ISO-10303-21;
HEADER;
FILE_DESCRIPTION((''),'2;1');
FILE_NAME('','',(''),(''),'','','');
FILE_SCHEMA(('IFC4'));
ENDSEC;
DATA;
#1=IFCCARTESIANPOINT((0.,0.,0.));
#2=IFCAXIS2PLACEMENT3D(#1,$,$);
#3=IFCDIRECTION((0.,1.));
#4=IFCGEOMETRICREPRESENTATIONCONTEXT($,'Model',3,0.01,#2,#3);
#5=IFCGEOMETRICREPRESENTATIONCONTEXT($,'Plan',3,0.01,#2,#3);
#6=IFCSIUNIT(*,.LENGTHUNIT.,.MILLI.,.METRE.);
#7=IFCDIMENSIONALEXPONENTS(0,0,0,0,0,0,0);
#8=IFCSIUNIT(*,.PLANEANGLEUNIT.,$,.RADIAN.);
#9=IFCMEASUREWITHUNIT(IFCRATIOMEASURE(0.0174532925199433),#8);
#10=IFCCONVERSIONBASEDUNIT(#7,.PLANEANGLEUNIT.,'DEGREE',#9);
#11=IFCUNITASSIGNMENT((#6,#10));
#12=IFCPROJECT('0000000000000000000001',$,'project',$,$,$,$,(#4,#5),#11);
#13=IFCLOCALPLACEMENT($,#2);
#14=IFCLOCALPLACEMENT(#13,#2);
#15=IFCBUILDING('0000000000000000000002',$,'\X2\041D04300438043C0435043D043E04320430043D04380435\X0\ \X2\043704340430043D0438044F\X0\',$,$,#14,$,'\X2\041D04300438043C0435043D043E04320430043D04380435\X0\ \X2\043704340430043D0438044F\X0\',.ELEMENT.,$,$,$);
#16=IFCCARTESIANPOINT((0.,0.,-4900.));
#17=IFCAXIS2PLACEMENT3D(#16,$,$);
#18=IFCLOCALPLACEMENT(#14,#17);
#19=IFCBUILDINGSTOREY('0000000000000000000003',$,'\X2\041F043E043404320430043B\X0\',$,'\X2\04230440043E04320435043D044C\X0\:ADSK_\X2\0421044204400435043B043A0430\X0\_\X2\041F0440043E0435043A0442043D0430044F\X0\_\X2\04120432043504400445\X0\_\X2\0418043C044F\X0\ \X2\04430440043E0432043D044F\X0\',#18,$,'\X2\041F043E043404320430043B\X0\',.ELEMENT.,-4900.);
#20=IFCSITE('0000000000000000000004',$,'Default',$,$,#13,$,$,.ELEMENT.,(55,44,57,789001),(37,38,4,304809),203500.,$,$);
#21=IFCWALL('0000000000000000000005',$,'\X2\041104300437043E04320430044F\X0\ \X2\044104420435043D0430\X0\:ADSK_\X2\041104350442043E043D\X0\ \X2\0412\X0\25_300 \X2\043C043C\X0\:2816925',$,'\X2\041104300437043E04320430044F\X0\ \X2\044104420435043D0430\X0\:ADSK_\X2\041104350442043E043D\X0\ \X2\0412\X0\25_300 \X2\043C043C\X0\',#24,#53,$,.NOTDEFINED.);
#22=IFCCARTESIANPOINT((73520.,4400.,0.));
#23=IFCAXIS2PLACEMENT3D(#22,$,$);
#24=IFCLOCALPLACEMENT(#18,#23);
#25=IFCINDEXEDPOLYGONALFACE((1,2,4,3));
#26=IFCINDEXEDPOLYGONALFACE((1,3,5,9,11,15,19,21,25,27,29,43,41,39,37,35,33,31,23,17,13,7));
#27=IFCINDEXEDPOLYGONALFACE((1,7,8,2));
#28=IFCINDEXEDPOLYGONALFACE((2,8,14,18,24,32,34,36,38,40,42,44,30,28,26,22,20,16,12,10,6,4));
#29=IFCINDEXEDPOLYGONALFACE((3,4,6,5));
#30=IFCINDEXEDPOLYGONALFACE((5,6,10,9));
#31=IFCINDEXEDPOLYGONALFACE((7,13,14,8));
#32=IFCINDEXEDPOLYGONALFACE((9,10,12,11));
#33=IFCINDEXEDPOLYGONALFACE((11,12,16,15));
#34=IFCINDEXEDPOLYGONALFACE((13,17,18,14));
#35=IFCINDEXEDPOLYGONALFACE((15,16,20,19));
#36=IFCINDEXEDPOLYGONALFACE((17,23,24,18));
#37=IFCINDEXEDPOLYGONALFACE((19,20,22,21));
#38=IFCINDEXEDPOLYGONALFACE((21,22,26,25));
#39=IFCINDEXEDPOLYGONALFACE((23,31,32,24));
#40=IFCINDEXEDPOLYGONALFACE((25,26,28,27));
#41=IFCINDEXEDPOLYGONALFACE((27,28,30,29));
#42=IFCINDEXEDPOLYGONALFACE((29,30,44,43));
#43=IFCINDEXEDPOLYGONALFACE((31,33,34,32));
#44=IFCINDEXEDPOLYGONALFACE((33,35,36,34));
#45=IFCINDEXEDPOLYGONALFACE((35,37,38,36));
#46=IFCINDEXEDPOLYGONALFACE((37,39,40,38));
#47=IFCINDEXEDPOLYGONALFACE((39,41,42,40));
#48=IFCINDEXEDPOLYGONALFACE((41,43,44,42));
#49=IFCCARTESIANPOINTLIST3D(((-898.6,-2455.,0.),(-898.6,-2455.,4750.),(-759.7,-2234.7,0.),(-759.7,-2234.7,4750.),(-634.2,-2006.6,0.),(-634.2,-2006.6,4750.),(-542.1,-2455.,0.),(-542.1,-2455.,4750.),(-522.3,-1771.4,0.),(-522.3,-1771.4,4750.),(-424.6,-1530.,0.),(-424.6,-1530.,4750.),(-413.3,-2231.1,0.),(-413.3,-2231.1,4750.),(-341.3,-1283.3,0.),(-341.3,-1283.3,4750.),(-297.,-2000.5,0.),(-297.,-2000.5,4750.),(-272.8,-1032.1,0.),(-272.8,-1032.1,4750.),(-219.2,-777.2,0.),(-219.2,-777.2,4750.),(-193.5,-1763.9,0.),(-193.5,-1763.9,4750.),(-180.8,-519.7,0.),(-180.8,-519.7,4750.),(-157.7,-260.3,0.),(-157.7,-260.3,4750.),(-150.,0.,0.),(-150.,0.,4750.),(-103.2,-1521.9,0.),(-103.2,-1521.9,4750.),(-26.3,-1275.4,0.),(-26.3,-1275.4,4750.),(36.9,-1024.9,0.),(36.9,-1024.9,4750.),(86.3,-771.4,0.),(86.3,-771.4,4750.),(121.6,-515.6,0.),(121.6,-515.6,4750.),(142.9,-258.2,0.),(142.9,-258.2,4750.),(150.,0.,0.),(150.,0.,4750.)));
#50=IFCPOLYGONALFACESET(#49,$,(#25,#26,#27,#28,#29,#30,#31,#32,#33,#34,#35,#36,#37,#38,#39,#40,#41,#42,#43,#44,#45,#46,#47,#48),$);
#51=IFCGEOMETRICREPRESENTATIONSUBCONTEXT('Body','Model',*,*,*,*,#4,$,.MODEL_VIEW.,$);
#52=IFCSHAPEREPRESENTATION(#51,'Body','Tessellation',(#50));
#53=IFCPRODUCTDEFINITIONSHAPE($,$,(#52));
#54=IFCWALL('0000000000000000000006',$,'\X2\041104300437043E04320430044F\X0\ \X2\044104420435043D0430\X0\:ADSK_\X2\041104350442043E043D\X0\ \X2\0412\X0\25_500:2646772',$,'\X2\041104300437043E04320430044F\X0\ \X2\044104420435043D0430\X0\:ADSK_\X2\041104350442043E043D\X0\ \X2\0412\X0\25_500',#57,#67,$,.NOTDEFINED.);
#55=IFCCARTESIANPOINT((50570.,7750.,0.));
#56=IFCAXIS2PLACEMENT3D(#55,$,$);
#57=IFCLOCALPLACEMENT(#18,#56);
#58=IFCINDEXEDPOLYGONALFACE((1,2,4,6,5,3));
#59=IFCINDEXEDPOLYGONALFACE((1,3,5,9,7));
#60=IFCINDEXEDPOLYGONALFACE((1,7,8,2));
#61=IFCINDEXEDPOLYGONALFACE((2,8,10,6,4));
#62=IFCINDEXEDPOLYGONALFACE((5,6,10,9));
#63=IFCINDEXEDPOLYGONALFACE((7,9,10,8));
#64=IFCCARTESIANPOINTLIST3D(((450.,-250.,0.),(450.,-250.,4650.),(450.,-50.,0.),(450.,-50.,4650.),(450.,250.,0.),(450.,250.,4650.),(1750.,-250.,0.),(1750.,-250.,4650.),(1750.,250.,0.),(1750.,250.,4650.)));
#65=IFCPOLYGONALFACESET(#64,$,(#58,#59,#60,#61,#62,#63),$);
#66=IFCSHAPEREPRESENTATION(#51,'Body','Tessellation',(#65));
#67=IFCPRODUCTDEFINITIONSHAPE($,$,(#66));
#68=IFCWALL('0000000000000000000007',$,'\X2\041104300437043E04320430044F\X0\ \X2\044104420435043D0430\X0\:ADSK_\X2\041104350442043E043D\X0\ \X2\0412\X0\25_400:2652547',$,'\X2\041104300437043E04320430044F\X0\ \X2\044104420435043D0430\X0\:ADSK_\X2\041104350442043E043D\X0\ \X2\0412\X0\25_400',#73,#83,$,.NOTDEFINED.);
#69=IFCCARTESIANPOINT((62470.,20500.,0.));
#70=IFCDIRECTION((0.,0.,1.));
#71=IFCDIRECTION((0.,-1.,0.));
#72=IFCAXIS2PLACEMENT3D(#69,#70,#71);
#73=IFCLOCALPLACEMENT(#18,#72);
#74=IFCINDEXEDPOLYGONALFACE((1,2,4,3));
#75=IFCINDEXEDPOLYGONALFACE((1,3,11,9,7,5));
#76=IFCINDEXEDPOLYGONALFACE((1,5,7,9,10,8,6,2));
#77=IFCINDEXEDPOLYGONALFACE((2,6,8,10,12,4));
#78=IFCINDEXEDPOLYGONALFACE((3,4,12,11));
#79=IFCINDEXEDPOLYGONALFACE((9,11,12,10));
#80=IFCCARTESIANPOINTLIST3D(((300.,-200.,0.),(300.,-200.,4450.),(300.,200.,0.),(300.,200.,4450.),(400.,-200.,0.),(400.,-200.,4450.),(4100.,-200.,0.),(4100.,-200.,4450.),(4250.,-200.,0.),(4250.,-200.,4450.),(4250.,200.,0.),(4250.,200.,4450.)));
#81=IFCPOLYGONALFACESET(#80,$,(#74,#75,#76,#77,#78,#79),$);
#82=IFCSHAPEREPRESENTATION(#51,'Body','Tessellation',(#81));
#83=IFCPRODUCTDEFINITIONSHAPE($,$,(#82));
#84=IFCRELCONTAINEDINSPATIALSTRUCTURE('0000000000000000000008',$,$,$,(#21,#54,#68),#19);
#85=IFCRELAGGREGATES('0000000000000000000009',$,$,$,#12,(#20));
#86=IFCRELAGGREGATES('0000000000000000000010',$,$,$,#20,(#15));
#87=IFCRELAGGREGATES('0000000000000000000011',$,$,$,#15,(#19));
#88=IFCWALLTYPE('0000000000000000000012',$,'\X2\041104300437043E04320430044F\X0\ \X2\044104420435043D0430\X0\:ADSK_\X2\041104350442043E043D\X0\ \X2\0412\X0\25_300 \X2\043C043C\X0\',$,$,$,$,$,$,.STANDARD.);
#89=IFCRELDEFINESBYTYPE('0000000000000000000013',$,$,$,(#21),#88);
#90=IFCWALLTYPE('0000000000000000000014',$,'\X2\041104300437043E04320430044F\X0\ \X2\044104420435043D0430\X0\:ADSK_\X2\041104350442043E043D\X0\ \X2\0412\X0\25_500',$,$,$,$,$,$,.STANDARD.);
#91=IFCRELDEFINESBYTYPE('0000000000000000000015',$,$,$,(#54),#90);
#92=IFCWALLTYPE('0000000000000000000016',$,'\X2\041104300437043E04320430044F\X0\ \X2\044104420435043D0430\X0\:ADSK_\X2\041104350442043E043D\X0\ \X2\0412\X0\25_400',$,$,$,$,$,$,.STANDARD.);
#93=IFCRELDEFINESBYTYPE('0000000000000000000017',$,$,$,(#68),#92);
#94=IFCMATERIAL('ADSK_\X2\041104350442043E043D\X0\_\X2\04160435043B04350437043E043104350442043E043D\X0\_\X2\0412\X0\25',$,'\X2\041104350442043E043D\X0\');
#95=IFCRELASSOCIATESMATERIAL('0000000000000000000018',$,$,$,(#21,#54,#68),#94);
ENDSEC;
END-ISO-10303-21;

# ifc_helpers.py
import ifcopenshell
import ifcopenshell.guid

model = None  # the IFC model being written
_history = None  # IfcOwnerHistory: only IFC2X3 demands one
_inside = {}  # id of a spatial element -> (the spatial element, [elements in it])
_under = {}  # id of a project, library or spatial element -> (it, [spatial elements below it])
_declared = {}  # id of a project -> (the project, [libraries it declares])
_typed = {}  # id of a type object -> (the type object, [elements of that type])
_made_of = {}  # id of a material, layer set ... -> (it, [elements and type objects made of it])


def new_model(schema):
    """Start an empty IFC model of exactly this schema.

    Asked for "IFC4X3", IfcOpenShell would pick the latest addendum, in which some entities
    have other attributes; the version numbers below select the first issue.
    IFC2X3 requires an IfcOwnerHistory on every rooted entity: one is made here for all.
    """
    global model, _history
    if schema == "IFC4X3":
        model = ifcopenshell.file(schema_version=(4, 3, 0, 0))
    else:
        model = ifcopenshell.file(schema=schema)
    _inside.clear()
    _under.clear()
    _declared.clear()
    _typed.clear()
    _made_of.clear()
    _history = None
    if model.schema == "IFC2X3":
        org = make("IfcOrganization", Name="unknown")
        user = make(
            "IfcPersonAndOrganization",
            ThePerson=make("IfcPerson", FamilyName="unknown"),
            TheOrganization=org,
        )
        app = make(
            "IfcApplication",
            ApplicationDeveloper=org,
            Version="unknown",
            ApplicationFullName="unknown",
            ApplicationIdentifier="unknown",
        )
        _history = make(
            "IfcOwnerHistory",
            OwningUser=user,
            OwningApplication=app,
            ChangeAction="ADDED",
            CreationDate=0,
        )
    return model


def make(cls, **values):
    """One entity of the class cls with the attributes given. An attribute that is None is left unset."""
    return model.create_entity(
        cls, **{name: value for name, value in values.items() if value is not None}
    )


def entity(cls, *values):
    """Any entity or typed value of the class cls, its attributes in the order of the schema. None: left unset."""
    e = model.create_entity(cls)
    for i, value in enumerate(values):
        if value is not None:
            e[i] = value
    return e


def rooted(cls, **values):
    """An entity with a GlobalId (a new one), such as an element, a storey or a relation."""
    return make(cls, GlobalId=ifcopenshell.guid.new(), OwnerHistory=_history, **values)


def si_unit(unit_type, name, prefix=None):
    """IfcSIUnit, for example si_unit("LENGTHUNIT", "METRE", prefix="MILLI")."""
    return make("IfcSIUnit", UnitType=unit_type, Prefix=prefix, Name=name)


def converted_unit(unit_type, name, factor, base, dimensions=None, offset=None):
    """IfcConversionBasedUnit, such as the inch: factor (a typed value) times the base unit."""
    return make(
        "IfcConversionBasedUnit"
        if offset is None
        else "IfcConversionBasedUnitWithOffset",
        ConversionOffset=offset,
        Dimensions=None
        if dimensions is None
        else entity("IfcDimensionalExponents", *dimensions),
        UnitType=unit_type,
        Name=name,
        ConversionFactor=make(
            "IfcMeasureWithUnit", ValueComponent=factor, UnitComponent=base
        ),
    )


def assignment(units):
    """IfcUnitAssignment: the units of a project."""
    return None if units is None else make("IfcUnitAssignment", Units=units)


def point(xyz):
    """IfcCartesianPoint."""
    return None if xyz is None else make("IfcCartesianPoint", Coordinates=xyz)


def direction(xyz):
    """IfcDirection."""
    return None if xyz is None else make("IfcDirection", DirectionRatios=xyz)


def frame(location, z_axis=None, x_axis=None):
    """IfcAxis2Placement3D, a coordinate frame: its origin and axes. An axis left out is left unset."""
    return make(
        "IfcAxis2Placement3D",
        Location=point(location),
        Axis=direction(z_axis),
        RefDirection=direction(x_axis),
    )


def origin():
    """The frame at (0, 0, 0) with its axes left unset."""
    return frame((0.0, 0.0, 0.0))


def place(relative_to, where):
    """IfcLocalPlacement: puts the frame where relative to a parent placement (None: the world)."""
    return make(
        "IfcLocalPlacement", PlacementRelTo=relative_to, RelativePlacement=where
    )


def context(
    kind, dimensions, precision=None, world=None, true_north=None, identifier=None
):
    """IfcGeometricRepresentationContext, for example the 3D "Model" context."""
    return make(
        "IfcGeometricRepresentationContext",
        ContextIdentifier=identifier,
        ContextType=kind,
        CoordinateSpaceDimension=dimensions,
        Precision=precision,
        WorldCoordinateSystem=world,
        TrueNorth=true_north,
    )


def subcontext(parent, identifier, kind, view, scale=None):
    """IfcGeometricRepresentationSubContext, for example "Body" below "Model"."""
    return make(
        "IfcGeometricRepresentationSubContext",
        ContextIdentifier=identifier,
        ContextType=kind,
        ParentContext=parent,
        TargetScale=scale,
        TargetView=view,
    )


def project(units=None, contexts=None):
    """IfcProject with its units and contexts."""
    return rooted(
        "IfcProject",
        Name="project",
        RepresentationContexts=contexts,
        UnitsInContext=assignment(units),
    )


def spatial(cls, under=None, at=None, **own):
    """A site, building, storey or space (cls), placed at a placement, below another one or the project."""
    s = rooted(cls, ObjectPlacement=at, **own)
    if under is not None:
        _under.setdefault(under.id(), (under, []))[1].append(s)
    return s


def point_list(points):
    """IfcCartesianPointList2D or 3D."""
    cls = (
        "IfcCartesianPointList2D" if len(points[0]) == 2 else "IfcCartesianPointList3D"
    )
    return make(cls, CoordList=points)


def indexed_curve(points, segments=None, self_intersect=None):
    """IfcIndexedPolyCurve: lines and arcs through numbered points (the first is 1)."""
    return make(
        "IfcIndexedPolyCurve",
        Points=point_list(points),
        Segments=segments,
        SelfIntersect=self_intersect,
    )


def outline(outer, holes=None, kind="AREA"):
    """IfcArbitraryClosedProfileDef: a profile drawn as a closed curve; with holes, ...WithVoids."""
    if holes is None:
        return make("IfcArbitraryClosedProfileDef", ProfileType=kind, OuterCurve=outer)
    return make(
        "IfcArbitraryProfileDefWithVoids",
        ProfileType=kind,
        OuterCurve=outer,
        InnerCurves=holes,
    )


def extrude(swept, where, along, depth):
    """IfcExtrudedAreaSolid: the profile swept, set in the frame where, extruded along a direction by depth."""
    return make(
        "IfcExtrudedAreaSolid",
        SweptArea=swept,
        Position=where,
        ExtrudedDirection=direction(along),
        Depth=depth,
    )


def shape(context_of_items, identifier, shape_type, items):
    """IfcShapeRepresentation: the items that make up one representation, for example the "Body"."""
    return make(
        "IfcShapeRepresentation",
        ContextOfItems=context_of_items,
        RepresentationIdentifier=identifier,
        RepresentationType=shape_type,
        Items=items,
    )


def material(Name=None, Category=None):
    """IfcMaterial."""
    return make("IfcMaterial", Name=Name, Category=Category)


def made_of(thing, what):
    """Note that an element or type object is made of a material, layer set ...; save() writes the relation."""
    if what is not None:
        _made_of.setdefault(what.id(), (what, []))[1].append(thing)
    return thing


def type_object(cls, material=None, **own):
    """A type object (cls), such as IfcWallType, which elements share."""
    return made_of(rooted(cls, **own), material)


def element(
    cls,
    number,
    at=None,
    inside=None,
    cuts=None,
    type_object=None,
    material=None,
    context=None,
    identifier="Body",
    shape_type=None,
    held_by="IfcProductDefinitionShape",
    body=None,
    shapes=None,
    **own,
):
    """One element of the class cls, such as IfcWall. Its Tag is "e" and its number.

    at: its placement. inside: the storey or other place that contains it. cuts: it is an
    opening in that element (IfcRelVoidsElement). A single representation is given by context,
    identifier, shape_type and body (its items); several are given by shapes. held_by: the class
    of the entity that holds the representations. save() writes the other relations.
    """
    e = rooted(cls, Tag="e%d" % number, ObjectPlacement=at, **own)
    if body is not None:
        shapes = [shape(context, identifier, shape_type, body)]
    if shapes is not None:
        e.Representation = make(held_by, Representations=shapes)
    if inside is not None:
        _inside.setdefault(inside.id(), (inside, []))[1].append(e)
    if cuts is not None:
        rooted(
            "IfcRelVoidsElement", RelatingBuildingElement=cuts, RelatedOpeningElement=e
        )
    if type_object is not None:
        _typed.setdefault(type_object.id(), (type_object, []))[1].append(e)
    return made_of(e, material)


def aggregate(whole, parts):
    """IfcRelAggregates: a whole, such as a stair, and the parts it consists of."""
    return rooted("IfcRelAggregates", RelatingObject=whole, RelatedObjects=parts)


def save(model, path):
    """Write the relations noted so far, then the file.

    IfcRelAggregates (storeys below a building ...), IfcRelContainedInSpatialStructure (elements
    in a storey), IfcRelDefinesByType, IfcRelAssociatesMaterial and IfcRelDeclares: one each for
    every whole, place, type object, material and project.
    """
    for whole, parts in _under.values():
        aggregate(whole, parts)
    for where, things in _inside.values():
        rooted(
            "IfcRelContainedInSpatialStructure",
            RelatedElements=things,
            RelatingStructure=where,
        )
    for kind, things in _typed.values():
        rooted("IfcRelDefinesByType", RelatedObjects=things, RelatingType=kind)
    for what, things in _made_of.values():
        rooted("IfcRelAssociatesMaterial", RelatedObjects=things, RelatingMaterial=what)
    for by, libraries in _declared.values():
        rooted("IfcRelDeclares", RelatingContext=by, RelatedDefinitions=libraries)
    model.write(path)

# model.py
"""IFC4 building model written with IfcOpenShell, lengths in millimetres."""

from ifc_helpers import new_model, entity, si_unit, converted_unit, direction, frame, origin, place, context, subcontext, project, spatial, indexed_curve, outline, extrude, material, type_object, element, save


model = new_model("IFC4")

# Units and contexts
model_context = context("Model", 3, precision=0.01, world=origin(), true_north=direction((0.0, 1.0)))
plan_context = context("Plan", 3, precision=0.01, world=origin(), true_north=direction((0.0, 1.0)))
body_context = subcontext(model_context, "Body", "Model", "MODEL_VIEW")
ifc_project = project(units=[si_unit("LENGTHUNIT", "METRE", prefix="MILLI"), converted_unit("PLANEANGLEUNIT", "DEGREE", entity("IfcRatioMeasure", 0.0174532925199433), si_unit("PLANEANGLEUNIT", "RADIAN"), dimensions=[0, 0, 0, 0, 0, 0, 0])], contexts=[model_context, plan_context])

# Site, building, storey
site_placement = place(None, origin())
site = spatial("IfcSite", under=ifc_project, at=site_placement, Name="Default", CompositionType="ELEMENT", RefLatitude=(55, 44, 57, 789001), RefLongitude=(37, 38, 4, 304809), RefElevation=203500.0)
building_placement = place(site_placement, origin())
building = spatial("IfcBuilding", under=site, at=building_placement, Name="Наименование здания", LongName="Наименование здания", CompositionType="ELEMENT")
storey_placement = place(building_placement, frame((0.0, 0.0, -4900.0)))
storey = spatial("IfcBuildingStorey", under=building, at=storey_placement, Name="Подвал", ObjectType="Уровень:ADSK_Стрелка_Проектная_Вверх_Имя уровня", LongName="Подвал", CompositionType="ELEMENT", Elevation=-4900.0)

# Shared definitions
ifc_material = material(Name="ADSK_Бетон_Железобетон_В25", Category="Бетон")

# Walls
wall_type_1 = type_object("IfcWallType", Name="Базовая стена:ADSK_Бетон В25_300 мм", PredefinedType="STANDARD")
wall_1_placement = place(storey_placement, frame((73520.0, 4400.0, 0.0)))
element("IfcWall", 1, at=wall_1_placement, inside=storey, type_object=wall_type_1, material=ifc_material, Name="Базовая стена:ADSK_Бетон В25_300 мм:2816925", ObjectType="Базовая стена:ADSK_Бетон В25_300 мм", PredefinedType="NOTDEFINED", context=body_context, shape_type="SweptSolid", body=[
    extrude(outline(indexed_curve([(-542.1, -2455.0), (-413.3, -2231.1), (-297.0, -2000.5), (-193.5, -1763.9), (-103.2, -1521.9), (-26.3, -1275.4), (36.9, -1024.9), (86.3, -771.4), (121.6, -515.6), (142.9, -258.2), (150.0, 0.0), (-150.0, 0.0), (-157.7, -260.3), (-180.8, -519.7), (-219.2, -777.2), (-272.8, -1032.1), (-341.3, -1283.3), (-424.6, -1530.0), (-522.3, -1771.4), (-634.2, -2006.6), (-759.7, -2234.7), (-898.6, -2455.0), (-542.1, -2455.0)], self_intersect=False)), origin(), (0.0, 0.0, 1.0), 4750.0),
])
wall_type_2 = type_object("IfcWallType", Name="Базовая стена:ADSK_Бетон В25_500", PredefinedType="STANDARD")
wall_2_placement = place(storey_placement, frame((50570.0, 7750.0, 0.0)))
element("IfcWall", 2, at=wall_2_placement, inside=storey, type_object=wall_type_2, material=ifc_material, Name="Базовая стена:ADSK_Бетон В25_500:2646772", ObjectType="Базовая стена:ADSK_Бетон В25_500", PredefinedType="NOTDEFINED", context=body_context, shape_type="SweptSolid", body=[
    extrude(outline(indexed_curve([(1750.0, -250.0), (1750.0, 250.0), (450.0, 250.0), (450.0, -50.0), (450.0, -250.0), (1750.0, -250.0)], self_intersect=False)), origin(), (0.0, 0.0, 1.0), 4650.0),
])
wall_type_3 = type_object("IfcWallType", Name="Базовая стена:ADSK_Бетон В25_400", PredefinedType="STANDARD")
wall_3_placement = place(storey_placement, frame((62470.0, 20500.0, 0.0), z_axis=(0.0, 0.0, 1.0), x_axis=(0.0, -1.0, 0.0)))
element("IfcWall", 3, at=wall_3_placement, inside=storey, type_object=wall_type_3, material=ifc_material, Name="Базовая стена:ADSK_Бетон В25_400:2652547", ObjectType="Базовая стена:ADSK_Бетон В25_400", PredefinedType="NOTDEFINED", context=body_context, shape_type="SweptSolid", body=[
    extrude(outline(indexed_curve([(4250.0, -200.0), (4250.0, 200.0), (300.0, 200.0), (300.0, -200.0), (400.0, -200.0), (4100.0, -200.0), (4250.0, -200.0)], self_intersect=False)), origin(), (0.0, 0.0, 1.0), 4450.0),
])

save(model, "model.ifc")
